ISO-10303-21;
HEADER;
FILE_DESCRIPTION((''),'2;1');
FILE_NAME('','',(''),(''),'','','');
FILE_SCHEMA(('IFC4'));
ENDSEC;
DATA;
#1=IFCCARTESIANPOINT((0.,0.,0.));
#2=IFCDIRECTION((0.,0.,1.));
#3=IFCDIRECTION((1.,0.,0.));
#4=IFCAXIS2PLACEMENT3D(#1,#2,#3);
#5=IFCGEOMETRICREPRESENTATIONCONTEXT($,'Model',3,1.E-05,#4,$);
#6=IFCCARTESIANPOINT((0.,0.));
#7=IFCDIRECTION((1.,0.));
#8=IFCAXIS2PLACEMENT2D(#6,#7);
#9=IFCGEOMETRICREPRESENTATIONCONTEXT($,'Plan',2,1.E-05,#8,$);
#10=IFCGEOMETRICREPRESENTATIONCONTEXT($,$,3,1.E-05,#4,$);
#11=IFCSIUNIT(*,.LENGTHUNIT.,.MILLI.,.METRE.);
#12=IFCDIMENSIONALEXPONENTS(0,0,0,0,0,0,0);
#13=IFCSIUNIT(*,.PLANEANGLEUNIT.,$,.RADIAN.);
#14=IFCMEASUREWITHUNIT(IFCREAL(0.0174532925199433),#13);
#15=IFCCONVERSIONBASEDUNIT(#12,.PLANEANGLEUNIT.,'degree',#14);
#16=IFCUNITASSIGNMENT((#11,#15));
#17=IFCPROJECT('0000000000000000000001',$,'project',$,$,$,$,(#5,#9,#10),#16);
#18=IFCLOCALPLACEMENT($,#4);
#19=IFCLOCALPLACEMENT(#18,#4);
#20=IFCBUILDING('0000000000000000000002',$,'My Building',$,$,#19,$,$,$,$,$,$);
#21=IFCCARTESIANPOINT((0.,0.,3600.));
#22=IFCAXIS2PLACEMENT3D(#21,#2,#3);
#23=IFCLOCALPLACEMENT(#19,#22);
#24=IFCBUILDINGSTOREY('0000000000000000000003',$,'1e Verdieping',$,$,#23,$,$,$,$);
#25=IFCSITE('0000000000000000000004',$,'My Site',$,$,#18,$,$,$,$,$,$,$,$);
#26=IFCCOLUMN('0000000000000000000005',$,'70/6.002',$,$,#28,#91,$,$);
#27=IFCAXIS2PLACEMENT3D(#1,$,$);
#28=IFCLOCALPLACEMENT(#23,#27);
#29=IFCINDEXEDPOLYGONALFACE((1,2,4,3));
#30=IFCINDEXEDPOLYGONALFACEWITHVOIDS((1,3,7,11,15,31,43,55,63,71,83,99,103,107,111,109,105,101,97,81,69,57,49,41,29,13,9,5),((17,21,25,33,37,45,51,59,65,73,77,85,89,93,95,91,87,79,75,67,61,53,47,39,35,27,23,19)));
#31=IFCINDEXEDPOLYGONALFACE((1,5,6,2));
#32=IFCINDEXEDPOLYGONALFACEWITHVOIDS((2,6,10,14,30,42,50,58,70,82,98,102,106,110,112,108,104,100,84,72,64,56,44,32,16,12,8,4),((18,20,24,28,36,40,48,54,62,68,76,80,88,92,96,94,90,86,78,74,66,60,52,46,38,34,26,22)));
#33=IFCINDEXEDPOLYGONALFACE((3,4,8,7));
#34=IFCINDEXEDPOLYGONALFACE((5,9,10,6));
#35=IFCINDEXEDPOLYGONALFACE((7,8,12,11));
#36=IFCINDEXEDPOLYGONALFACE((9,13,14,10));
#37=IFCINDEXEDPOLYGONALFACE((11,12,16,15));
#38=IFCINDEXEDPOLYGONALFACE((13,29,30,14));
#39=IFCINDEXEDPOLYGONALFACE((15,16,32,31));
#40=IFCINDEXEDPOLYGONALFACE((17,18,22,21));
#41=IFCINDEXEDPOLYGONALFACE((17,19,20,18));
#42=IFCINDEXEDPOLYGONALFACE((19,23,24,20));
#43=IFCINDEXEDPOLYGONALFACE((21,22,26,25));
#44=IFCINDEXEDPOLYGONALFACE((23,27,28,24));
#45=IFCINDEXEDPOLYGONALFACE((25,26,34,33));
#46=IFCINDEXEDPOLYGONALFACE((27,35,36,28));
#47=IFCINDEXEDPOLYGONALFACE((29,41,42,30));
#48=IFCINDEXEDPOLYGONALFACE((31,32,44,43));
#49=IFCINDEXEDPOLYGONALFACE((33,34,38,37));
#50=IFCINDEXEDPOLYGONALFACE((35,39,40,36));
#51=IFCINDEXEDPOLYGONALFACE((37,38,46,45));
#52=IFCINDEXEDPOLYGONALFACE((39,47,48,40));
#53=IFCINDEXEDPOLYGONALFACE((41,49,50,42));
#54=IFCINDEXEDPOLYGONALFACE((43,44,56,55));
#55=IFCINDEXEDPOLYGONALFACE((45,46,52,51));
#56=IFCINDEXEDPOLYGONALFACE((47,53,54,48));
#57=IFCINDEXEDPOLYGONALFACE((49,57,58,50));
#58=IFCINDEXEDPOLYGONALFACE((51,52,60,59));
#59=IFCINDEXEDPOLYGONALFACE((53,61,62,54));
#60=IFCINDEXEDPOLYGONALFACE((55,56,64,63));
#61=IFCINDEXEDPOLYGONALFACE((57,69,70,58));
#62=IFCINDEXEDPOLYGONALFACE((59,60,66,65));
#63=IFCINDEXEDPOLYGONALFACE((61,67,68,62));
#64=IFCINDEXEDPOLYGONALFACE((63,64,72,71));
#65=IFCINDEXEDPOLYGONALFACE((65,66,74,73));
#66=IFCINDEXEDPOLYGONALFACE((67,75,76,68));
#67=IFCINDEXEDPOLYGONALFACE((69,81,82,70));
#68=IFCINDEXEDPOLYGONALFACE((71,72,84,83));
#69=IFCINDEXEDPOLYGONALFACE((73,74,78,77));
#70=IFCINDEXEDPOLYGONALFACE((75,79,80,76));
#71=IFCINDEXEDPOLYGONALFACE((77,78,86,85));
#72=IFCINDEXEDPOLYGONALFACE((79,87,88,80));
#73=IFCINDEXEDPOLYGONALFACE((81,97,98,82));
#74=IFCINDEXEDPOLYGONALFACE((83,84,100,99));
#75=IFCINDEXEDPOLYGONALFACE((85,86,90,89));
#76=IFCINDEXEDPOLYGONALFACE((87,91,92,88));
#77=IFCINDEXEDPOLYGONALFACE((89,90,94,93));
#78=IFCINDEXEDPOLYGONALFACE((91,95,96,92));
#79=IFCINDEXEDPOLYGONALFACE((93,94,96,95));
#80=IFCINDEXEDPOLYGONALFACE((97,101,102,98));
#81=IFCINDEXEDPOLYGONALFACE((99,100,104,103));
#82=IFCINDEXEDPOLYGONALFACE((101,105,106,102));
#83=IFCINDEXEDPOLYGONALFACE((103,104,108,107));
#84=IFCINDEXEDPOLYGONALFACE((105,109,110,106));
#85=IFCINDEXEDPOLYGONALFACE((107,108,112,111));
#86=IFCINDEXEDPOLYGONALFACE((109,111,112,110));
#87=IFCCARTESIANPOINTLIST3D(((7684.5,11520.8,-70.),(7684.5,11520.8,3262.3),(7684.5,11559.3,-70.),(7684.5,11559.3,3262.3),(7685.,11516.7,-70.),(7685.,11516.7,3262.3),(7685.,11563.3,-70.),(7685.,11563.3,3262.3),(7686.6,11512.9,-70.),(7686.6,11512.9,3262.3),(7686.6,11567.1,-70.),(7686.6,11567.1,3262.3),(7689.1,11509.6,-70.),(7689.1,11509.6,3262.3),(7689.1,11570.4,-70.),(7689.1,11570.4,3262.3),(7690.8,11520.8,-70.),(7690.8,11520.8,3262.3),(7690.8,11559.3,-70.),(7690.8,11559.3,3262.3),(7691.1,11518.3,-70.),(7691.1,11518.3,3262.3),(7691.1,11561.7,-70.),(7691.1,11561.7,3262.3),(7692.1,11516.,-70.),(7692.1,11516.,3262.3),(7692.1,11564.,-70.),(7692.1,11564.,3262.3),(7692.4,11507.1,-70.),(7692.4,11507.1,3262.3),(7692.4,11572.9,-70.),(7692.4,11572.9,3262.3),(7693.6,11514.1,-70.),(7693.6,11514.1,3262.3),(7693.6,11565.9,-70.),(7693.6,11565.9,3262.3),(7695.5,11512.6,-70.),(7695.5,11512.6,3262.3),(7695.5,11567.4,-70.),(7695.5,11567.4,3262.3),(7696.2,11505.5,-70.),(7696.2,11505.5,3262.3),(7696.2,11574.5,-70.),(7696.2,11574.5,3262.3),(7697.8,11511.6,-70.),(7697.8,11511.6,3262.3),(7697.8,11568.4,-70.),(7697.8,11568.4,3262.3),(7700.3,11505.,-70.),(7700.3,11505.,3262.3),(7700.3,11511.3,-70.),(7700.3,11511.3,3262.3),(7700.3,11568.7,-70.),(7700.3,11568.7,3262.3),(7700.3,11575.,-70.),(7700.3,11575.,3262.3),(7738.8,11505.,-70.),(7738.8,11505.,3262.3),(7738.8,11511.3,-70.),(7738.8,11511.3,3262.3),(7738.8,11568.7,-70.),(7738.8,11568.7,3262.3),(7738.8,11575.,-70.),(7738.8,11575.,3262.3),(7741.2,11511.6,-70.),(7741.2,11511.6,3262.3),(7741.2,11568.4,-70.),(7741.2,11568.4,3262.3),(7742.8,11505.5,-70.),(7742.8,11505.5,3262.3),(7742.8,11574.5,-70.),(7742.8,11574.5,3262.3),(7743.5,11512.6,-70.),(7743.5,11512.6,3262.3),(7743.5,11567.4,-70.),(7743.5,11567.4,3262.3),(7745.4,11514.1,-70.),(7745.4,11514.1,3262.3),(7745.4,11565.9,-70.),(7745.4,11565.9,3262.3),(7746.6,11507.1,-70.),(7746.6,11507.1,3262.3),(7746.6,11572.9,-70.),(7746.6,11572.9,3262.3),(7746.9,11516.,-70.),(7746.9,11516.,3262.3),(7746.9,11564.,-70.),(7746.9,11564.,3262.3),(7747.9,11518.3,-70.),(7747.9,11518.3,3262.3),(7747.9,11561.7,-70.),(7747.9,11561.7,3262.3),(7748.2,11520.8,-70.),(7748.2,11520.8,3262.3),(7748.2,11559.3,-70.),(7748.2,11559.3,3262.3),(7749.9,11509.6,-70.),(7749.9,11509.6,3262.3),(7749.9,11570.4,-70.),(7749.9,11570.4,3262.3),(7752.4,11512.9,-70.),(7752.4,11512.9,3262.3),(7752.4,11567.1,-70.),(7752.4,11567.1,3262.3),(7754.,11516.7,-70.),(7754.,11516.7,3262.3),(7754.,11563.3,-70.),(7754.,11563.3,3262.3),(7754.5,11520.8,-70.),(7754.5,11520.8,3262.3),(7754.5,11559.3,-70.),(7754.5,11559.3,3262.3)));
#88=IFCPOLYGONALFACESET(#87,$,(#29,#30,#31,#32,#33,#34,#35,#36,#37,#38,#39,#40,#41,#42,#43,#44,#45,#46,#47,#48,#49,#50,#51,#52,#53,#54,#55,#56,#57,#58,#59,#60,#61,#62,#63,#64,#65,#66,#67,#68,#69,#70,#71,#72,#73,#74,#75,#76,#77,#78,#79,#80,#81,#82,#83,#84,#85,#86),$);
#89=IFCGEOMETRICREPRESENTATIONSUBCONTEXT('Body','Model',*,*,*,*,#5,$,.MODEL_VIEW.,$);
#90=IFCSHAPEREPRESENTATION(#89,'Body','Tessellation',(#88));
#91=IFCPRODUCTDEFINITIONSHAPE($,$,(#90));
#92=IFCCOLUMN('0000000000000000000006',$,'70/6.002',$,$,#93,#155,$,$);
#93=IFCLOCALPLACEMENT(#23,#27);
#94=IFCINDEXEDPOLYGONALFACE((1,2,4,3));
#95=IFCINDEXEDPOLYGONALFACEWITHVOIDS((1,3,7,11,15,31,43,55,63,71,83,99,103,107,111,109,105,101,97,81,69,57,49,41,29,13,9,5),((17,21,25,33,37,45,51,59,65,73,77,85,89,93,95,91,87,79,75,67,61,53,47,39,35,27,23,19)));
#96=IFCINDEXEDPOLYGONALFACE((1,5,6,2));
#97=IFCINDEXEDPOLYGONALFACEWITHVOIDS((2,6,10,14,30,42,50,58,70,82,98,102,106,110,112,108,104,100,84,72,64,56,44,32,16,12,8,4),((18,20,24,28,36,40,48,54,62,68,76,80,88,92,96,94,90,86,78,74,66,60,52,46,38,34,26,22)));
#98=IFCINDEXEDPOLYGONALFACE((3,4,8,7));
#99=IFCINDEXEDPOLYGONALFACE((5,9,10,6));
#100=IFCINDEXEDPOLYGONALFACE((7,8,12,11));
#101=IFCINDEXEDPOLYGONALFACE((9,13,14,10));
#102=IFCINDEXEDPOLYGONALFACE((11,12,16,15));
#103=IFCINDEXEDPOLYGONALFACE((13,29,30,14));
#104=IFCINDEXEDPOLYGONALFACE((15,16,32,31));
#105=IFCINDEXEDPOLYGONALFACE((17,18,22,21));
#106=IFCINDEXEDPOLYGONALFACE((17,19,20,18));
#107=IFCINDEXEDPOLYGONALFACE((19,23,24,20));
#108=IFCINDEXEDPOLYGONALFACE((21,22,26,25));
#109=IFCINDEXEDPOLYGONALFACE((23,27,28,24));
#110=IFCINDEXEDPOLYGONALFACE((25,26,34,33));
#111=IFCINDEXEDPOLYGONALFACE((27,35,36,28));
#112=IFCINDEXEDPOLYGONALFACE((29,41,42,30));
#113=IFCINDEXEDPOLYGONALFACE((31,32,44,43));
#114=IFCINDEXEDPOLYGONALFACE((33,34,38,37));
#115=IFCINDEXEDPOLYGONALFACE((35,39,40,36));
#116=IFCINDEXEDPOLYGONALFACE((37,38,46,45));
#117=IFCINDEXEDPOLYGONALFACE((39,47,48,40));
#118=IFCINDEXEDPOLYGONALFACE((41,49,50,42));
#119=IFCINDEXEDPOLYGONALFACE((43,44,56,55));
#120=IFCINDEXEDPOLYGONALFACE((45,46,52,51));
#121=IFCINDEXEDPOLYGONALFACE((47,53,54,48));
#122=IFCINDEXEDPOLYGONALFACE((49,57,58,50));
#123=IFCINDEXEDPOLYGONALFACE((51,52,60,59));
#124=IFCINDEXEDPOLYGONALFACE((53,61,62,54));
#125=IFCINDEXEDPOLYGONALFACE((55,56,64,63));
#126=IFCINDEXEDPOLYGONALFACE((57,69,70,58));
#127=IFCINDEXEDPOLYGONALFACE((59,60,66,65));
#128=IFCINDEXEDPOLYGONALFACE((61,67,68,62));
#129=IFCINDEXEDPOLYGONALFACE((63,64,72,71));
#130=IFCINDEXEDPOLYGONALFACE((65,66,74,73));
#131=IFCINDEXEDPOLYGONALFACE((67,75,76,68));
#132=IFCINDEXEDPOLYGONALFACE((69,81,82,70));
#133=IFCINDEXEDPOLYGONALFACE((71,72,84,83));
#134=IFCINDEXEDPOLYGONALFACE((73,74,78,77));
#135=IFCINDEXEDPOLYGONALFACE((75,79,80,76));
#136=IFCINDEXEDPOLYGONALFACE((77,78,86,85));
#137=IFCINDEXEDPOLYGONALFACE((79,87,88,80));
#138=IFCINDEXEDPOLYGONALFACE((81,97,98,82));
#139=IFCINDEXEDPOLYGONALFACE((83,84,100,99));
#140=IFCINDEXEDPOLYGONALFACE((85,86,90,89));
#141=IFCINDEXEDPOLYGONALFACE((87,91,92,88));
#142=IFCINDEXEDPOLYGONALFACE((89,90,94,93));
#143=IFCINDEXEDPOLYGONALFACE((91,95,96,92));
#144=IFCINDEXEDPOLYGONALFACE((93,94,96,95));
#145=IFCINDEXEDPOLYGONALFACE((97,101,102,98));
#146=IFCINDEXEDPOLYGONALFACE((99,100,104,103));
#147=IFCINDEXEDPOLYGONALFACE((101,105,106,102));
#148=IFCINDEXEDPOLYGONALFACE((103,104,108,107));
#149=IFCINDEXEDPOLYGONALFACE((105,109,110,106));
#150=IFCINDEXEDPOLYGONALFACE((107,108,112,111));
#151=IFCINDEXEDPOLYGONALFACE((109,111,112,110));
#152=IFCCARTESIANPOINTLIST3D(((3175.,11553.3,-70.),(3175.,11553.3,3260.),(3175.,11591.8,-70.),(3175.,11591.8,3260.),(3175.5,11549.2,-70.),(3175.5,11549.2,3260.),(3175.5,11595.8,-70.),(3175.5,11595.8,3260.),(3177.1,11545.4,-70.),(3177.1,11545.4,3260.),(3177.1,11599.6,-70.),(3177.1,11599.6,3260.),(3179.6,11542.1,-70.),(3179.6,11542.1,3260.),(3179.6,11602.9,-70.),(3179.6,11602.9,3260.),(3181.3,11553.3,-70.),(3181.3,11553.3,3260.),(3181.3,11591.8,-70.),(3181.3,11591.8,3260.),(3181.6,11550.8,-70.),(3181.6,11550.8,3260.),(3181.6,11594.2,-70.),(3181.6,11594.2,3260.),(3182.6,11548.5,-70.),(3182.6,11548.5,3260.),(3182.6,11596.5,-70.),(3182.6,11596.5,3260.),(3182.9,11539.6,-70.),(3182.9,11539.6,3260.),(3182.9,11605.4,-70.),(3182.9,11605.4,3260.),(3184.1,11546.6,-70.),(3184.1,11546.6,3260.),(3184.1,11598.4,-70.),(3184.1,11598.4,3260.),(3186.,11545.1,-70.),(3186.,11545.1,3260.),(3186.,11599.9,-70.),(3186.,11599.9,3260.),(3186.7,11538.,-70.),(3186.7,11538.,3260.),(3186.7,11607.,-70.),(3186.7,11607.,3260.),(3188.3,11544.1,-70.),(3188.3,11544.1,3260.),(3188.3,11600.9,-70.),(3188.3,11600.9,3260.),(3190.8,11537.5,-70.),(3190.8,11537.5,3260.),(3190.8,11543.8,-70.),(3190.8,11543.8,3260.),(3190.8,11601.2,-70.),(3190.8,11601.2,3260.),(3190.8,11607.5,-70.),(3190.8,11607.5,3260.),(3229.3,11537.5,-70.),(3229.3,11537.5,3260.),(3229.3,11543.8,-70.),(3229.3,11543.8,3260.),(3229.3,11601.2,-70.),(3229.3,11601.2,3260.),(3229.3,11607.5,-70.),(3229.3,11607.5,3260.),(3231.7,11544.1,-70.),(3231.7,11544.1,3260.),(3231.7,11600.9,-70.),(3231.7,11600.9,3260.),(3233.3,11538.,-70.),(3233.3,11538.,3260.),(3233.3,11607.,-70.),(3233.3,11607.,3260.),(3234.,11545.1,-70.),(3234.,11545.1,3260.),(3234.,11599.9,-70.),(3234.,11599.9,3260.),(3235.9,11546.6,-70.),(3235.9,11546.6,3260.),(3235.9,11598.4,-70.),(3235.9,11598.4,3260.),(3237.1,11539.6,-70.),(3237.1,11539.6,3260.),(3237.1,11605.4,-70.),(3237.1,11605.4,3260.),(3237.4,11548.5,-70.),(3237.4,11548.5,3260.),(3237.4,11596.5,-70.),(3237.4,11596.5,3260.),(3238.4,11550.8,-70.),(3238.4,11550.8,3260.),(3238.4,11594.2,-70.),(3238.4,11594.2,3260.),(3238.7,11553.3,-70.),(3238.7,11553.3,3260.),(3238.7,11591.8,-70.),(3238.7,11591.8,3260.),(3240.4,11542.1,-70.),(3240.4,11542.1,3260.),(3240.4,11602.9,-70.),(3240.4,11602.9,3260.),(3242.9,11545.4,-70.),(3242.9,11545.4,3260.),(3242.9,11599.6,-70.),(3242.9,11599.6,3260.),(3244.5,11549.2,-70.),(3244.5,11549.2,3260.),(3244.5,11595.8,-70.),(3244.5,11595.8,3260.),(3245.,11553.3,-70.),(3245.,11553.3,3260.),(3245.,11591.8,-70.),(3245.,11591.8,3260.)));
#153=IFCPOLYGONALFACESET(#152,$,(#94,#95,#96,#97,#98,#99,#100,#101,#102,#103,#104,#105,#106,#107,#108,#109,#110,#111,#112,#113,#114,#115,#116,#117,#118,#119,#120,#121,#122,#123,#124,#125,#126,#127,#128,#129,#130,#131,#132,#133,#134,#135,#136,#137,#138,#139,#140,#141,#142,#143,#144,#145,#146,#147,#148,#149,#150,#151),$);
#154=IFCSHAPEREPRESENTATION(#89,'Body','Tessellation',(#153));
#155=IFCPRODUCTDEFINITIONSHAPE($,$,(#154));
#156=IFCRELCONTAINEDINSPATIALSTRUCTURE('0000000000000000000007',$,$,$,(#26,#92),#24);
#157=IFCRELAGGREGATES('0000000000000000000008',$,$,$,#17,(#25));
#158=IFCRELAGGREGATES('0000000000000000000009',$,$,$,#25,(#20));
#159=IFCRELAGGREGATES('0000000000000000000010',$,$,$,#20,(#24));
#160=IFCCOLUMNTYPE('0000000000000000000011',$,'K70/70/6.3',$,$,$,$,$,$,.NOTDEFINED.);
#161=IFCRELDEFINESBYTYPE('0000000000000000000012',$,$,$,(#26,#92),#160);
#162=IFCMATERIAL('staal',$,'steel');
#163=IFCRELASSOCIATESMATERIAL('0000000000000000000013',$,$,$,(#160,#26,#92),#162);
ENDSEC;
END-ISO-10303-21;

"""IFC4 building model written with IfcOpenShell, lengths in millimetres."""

from ifc_helpers import new_model, entity, si_unit, converted_unit, frame, origin_with_axes, origin_2d_with_axis, place, context, subcontext, project, spatial, hollow_rectangle, extrude, material, material_profile, profile_set, profile_usage, type_object, element, save


model = new_model("IFC4")

# Units and contexts
model_context = context("Model", 3, precision=1e-05, world=origin_with_axes())
plan_context = context("Plan", 2, precision=1e-05, world=origin_2d_with_axis())
context_of_model = context(None, 3, precision=1e-05, world=origin_with_axes())
body_context = subcontext(model_context, "Body", "Model", "MODEL_VIEW")
ifc_project = project(units=[si_unit("LENGTHUNIT", "METRE", prefix="MILLI"), converted_unit("PLANEANGLEUNIT", "degree", entity("IfcReal", 0.0174532925199433), si_unit("PLANEANGLEUNIT", "RADIAN"), dimensions=[0, 0, 0, 0, 0, 0, 0])], contexts=[model_context, plan_context, context_of_model])

# Site, building, storey
site_placement = place(None, origin_with_axes())
site = spatial("IfcSite", under=ifc_project, at=site_placement, Name="My Site")
building_placement = place(site_placement, origin_with_axes())
building = spatial("IfcBuilding", under=site, at=building_placement, Name="My Building")
storey_placement = place(building_placement, frame((0.0, 0.0, 3600.0), z_axis=(0.0, 0.0, 1.0), x_axis=(1.0, 0.0, 0.0)))
storey = spatial("IfcBuildingStorey", under=building, at=storey_placement, Name="1e Verdieping")

# Columns
ifc_material_1 = material(Name="staal", Category="steel")
ifc_material_profile_1 = material_profile(ifc_material_1, hollow_rectangle(XDim=70.0, YDim=70.0, WallThickness=6.3, InnerFilletRadius=9.4, OuterFilletRadius=15.8))
ifc_profile_set_1 = profile_set([ifc_material_profile_1], Name="K70/70/6.3")
column_type_1 = type_object("IfcColumnType", Name="K70/70/6.3", PredefinedType="NOTDEFINED", material=ifc_profile_set_1)
ifc_profile_usage_1 = profile_usage(ifc_profile_set_1)
column_1_placement = place(storey_placement, frame((7719.5, 11540.0, -70.0), z_axis=(0.0, 0.0, 1.0), x_axis=(1.0, 0.0, 0.0)))
element("IfcColumn", 1, at=column_1_placement, inside=storey, type_object=column_type_1, material=ifc_profile_usage_1, Name="70/6.002", context=body_context, shape_type="SweptSolid", body=[
    extrude(hollow_rectangle(XDim=70.0, YDim=70.0, WallThickness=6.3, InnerFilletRadius=9.4, OuterFilletRadius=15.8), origin_with_axes(), (0.0, 0.0, 1.0), 3332.3),
])
ifc_profile_usage_2 = profile_usage(ifc_profile_set_1)
column_2_placement = place(storey_placement, frame((3210.0, 11572.5, -70.0), z_axis=(0.0, 0.0, 1.0), x_axis=(1.0, 0.0, 0.0)))
element("IfcColumn", 2, at=column_2_placement, inside=storey, type_object=column_type_1, material=ifc_profile_usage_2, Name="70/6.002", context=body_context, shape_type="SweptSolid", body=[
    extrude(hollow_rectangle(XDim=70.0, YDim=70.0, WallThickness=6.3, InnerFilletRadius=9.4, OuterFilletRadius=15.8), origin_with_axes(), (0.0, 0.0, 1.0), 3330.0),
])

save(model, "model.ifc")
